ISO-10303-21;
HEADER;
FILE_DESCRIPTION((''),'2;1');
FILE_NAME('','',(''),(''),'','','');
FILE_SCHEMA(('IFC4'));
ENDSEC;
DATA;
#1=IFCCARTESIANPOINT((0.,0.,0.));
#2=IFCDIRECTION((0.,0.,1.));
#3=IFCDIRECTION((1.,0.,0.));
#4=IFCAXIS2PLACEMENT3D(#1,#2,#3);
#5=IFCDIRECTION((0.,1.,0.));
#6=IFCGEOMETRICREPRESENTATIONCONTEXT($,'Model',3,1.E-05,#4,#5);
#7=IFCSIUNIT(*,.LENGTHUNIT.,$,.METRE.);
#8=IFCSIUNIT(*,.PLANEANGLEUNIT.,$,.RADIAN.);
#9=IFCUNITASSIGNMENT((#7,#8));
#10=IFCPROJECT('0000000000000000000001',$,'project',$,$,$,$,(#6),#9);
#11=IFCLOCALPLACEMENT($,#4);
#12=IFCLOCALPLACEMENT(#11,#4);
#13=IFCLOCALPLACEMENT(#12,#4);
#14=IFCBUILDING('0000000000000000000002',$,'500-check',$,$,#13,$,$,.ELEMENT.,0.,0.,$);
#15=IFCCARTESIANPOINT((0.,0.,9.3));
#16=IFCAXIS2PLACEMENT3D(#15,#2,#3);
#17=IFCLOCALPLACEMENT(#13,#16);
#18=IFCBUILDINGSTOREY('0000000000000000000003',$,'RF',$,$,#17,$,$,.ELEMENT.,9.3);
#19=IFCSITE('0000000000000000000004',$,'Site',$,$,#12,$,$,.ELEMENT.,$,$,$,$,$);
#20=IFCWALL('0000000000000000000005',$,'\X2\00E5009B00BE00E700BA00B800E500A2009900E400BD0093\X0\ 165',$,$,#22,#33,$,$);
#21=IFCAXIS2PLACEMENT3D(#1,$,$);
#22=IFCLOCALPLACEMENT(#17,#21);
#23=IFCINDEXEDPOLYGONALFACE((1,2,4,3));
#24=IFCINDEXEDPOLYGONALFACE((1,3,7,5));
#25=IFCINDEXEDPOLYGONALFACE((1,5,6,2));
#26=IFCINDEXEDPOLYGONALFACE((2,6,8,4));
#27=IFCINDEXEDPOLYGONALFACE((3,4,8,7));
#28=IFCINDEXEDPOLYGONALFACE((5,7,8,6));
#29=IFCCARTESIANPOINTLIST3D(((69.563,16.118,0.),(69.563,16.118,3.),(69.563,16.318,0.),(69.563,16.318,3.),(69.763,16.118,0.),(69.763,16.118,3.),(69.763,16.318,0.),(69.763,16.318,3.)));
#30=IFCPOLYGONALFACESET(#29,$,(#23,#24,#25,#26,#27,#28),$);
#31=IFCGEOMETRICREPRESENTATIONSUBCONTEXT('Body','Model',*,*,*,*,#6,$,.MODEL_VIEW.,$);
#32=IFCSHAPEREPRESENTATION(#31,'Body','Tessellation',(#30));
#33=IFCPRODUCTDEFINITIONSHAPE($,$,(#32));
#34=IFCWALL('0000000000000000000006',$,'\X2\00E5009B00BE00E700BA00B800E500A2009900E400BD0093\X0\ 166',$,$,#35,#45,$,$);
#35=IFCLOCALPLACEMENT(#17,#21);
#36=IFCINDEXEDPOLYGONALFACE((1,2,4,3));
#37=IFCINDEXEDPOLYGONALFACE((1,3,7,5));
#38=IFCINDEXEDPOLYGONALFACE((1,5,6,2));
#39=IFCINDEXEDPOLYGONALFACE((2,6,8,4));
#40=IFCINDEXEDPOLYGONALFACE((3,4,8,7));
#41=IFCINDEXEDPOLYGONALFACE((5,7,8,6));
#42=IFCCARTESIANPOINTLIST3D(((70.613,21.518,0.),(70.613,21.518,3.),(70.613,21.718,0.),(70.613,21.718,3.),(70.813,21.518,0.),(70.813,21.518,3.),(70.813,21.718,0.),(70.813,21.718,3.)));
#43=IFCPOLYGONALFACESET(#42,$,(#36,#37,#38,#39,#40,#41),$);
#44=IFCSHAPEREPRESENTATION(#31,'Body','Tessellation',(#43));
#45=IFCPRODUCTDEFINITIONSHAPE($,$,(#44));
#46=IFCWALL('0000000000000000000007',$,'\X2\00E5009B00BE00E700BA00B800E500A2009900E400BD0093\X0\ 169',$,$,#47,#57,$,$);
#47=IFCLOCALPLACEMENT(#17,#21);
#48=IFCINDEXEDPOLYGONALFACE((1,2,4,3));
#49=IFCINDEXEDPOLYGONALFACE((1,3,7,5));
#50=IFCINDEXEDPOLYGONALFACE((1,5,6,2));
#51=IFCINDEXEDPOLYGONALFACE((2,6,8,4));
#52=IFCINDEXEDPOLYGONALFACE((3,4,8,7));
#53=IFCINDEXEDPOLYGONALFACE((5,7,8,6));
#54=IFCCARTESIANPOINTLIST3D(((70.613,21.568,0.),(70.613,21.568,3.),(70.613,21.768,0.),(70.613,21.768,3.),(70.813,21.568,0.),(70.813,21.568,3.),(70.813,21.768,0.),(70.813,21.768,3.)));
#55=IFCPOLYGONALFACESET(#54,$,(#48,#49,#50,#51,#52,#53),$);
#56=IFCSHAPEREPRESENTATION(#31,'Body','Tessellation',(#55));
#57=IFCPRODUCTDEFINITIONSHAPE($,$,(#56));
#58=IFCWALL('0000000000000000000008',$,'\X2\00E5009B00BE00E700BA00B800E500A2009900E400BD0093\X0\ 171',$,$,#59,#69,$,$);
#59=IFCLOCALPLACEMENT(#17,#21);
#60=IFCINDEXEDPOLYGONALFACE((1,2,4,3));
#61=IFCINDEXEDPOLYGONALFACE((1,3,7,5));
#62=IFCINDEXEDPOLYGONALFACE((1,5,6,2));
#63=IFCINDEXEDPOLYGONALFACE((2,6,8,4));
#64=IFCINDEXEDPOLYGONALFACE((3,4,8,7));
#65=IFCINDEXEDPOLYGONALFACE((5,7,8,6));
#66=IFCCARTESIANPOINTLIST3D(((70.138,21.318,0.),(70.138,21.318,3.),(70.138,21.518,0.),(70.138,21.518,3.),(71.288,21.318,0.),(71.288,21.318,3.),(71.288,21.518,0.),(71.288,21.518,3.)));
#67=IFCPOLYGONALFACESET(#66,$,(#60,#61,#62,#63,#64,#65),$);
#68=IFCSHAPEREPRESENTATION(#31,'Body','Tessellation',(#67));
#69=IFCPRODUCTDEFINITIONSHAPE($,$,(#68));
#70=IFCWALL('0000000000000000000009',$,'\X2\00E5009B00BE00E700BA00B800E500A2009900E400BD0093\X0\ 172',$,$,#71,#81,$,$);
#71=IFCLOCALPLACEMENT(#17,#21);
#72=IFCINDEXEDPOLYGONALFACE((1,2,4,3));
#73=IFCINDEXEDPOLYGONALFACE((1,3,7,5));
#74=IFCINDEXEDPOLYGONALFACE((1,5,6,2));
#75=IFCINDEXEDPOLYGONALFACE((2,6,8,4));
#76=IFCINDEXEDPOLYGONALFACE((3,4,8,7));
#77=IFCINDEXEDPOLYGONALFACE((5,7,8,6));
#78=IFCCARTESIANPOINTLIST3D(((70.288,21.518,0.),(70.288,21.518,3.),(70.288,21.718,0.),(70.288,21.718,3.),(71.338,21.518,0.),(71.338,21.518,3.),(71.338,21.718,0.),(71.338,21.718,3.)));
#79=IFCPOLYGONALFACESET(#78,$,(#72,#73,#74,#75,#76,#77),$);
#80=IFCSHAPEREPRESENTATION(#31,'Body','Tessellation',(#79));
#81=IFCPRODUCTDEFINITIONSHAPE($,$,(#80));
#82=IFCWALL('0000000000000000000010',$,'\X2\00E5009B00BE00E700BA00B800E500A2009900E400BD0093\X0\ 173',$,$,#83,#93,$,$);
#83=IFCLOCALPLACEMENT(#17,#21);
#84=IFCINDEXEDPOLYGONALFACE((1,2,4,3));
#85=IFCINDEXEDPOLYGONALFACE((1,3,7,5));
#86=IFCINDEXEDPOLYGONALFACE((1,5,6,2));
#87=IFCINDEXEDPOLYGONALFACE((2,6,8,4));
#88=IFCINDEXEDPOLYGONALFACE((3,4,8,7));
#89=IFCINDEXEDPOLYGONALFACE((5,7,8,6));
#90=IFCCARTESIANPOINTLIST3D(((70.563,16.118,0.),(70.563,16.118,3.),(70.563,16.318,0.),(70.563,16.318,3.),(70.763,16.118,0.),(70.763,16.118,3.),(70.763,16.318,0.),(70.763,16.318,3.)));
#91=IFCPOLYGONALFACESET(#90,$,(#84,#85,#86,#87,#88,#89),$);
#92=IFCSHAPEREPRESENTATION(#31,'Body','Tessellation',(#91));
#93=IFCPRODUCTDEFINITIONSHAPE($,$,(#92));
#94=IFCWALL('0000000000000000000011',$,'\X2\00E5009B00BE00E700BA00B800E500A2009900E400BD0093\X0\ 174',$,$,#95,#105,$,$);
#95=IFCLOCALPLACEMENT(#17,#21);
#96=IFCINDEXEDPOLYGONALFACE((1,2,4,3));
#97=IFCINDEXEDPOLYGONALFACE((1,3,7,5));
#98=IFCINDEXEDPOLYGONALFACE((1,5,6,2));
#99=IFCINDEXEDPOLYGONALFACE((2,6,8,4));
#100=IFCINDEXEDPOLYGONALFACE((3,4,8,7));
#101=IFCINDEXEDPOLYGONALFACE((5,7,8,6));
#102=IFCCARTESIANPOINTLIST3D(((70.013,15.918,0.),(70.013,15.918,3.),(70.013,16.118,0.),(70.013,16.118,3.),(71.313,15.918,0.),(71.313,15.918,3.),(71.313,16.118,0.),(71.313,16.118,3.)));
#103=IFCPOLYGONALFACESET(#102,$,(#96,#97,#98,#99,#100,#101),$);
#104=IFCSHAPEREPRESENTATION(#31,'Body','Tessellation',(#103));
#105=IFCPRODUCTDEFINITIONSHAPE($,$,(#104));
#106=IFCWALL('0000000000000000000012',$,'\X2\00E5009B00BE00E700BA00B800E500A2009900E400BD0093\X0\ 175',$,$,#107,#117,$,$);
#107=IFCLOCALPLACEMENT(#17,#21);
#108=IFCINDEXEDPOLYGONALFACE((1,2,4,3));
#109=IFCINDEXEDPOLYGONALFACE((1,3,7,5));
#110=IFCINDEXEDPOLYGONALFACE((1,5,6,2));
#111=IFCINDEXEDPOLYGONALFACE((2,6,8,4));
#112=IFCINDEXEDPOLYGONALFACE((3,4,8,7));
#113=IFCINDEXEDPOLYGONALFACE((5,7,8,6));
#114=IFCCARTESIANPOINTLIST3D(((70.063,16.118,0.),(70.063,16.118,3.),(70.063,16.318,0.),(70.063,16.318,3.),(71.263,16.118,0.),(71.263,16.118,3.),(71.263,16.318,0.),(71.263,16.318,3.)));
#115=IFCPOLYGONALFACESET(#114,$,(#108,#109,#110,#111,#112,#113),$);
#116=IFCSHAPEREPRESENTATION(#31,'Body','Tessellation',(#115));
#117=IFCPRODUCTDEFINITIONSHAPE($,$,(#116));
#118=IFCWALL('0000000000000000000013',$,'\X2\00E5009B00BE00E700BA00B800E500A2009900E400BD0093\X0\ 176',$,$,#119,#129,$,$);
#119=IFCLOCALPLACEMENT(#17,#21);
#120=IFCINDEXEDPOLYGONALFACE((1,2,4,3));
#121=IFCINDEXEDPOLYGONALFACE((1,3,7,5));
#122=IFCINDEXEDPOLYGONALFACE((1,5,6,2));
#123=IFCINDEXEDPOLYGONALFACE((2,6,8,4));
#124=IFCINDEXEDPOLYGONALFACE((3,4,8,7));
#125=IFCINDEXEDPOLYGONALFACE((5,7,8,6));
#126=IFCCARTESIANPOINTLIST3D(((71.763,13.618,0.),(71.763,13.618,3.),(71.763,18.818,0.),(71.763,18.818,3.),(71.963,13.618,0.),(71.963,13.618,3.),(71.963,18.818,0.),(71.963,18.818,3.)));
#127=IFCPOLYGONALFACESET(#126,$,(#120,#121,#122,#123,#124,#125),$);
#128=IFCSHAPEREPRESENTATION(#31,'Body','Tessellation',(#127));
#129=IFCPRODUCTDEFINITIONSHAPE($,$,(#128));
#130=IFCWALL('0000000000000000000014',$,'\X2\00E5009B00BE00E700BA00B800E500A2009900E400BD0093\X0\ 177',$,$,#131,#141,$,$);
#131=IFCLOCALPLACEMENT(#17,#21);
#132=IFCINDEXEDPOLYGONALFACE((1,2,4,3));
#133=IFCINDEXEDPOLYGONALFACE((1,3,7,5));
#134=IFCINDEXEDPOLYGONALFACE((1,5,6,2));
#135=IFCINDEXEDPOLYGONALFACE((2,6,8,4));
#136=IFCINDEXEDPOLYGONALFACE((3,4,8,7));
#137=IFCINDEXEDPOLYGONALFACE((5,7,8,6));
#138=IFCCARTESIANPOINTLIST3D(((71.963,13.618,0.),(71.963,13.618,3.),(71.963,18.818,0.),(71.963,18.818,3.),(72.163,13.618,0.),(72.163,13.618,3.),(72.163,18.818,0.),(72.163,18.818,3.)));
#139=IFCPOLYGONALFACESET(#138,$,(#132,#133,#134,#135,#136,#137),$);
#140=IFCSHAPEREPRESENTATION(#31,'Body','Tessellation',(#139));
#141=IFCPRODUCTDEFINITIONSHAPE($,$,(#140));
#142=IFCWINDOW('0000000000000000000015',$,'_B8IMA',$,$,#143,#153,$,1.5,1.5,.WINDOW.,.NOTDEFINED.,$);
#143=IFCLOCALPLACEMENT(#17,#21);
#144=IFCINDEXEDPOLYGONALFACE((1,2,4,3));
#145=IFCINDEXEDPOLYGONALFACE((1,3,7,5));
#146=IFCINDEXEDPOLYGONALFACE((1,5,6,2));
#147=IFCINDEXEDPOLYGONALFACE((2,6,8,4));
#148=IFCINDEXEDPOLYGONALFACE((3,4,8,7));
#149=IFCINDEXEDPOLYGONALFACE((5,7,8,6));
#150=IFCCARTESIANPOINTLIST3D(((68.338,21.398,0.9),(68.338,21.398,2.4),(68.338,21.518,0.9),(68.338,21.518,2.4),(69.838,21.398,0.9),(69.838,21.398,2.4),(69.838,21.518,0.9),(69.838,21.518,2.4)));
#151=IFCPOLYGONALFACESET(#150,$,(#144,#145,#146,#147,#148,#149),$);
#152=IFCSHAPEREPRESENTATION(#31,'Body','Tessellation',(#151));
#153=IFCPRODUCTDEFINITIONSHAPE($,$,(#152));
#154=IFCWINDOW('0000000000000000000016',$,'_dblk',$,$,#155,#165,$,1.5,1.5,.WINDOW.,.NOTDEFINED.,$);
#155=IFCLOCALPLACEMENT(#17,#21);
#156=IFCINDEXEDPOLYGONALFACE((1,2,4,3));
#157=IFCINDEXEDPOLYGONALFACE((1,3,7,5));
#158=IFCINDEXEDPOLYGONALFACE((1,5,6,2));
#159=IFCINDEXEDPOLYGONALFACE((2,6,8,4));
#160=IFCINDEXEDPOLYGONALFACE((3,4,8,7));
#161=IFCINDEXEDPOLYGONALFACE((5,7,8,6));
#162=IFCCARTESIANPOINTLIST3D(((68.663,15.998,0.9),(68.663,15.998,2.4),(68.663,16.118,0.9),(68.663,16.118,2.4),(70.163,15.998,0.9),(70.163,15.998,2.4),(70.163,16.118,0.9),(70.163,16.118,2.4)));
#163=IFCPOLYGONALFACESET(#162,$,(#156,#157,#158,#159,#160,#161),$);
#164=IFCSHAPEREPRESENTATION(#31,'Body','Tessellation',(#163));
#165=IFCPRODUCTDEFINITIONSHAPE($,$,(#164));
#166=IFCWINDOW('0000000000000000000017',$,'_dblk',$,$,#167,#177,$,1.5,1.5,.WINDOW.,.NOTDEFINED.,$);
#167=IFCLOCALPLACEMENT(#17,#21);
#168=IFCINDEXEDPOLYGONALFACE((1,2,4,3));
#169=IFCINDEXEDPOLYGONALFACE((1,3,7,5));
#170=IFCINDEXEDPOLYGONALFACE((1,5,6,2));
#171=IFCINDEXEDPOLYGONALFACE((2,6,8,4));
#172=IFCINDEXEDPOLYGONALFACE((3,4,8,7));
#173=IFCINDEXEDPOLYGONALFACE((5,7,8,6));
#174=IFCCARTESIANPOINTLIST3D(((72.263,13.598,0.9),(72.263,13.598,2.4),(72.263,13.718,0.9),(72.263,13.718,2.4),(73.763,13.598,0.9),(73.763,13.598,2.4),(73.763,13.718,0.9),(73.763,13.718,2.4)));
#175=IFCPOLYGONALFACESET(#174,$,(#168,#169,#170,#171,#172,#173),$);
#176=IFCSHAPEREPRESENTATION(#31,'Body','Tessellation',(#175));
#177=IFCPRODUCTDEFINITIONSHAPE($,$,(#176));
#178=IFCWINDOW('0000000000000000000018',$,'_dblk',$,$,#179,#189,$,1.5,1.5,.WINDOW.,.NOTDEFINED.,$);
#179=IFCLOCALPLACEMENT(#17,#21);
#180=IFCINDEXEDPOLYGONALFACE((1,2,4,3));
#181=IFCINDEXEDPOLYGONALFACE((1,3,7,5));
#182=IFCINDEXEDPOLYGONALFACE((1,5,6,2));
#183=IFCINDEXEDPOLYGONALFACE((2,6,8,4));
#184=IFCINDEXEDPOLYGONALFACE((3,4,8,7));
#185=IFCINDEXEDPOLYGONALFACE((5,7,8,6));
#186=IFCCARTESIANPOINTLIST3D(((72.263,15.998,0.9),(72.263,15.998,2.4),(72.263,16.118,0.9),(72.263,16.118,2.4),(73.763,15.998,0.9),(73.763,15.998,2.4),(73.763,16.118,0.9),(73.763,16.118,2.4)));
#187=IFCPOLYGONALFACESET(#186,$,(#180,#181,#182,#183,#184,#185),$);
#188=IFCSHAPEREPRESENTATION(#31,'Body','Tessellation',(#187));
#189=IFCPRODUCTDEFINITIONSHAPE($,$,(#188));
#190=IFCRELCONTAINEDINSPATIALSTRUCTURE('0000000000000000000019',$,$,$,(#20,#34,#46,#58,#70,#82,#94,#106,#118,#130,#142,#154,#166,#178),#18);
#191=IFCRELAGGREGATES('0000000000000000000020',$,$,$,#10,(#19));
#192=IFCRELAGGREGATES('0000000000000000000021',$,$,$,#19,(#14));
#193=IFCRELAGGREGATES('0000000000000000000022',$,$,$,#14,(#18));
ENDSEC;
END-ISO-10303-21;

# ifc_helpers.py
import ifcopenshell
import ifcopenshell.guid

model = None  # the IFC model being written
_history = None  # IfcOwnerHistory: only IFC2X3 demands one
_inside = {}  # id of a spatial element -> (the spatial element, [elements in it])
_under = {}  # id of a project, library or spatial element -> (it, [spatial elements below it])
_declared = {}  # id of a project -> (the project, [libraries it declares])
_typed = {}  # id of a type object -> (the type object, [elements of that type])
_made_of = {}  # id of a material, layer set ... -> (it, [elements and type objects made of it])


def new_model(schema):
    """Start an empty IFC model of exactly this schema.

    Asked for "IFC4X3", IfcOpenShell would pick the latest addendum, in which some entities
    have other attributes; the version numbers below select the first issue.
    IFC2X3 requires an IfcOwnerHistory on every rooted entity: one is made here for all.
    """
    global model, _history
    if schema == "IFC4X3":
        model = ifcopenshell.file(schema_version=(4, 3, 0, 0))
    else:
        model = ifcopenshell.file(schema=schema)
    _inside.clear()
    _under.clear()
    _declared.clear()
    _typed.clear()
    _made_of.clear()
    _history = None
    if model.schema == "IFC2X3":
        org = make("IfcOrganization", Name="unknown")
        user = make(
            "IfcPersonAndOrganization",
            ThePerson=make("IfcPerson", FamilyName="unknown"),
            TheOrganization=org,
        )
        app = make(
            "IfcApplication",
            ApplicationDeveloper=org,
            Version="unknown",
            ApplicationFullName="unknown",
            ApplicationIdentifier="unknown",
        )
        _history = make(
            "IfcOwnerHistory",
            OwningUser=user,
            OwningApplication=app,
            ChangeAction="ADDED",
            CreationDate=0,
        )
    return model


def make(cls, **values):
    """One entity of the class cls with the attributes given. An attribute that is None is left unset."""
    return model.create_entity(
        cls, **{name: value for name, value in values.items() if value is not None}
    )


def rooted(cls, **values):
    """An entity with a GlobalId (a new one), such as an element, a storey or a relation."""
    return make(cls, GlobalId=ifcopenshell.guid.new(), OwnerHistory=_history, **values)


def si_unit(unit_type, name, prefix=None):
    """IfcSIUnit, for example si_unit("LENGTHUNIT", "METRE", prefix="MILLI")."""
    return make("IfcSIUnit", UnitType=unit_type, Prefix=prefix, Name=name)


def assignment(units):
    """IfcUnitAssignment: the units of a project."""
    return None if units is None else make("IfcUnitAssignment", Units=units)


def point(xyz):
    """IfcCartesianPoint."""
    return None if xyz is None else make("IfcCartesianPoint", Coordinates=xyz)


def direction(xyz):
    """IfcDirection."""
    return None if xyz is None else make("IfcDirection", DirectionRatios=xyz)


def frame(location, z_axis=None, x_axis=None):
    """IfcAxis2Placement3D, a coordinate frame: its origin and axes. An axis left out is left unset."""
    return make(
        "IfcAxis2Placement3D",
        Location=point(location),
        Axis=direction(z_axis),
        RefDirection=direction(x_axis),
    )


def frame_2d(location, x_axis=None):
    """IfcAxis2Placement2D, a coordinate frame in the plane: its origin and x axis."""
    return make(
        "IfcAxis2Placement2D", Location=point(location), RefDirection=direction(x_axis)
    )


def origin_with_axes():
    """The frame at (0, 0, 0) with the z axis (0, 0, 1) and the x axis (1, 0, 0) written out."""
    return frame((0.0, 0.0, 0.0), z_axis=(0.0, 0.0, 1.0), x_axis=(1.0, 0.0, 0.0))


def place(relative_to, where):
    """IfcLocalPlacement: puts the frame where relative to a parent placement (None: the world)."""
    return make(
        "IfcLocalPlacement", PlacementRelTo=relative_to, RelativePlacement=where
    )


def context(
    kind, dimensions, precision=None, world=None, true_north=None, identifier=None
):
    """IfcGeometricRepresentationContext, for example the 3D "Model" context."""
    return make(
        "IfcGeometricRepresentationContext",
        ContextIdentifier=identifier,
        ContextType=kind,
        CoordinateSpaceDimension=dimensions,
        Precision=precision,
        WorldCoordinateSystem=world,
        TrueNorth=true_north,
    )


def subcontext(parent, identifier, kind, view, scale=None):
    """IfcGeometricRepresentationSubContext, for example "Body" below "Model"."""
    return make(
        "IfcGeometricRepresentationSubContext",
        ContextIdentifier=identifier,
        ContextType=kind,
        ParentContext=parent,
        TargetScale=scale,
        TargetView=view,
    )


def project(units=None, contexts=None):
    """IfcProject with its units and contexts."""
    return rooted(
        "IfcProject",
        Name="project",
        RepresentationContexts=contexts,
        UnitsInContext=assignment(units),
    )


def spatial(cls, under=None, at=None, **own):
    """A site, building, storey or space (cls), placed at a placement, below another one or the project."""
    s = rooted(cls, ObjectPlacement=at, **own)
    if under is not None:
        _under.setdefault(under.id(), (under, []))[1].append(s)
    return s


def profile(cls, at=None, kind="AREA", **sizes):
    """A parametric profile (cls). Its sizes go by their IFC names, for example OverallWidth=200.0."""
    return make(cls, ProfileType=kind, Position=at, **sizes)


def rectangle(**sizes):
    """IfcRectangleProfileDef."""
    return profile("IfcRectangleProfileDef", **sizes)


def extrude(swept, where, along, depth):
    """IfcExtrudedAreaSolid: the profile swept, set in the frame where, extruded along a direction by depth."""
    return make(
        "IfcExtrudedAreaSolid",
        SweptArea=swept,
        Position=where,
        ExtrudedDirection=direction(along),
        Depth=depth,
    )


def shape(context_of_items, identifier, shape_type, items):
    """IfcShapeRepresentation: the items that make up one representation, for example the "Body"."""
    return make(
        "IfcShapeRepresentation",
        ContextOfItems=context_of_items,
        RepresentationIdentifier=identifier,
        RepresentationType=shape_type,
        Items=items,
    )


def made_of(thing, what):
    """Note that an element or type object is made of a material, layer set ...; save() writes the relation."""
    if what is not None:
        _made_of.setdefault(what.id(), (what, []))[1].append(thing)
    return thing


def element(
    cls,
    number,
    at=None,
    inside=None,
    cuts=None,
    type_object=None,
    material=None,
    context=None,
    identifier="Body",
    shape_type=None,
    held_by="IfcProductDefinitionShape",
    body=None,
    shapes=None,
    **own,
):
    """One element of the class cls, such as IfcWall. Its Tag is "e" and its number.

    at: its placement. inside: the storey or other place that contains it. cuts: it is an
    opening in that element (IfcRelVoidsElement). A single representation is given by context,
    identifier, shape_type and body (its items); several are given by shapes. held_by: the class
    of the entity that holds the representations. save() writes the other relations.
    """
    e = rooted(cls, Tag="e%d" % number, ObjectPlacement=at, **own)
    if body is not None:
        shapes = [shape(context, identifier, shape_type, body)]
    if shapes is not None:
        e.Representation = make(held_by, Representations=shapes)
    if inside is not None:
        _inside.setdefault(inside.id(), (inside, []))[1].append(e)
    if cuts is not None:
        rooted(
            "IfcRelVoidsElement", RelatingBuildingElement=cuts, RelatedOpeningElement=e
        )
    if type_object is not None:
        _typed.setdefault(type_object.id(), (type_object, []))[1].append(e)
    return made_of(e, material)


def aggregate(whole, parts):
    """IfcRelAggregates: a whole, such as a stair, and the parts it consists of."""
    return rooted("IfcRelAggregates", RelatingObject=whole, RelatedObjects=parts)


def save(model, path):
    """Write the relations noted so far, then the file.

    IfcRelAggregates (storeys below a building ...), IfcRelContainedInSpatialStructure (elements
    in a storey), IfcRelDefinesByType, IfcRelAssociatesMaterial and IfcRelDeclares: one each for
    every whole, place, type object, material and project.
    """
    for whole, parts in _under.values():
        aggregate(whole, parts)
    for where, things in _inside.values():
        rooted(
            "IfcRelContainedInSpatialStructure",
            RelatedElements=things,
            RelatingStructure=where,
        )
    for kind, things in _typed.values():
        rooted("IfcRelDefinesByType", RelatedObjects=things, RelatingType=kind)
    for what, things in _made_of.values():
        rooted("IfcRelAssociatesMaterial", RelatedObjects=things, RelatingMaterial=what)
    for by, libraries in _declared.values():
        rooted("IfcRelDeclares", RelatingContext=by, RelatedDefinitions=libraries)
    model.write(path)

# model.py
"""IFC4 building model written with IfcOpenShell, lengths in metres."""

from ifc_helpers import new_model, si_unit, direction, frame, frame_2d, origin_with_axes, place, context, subcontext, project, spatial, rectangle, extrude, element, save


model = new_model("IFC4")

# Units and contexts
model_context = context("Model", 3, precision=1e-05, world=origin_with_axes(), true_north=direction((0.0, 1.0, 0.0)))
body_context = subcontext(model_context, "Body", "Model", "MODEL_VIEW")
ifc_project = project(units=[si_unit("LENGTHUNIT", "METRE"), si_unit("PLANEANGLEUNIT", "RADIAN")], contexts=[model_context])

# Site, building, storey
placement = place(None, origin_with_axes())
site_placement = place(placement, origin_with_axes())
site = spatial("IfcSite", under=ifc_project, at=site_placement, Name="Site", CompositionType="ELEMENT")
building_placement = place(site_placement, origin_with_axes())
building = spatial("IfcBuilding", under=site, at=building_placement, Name="500-check", CompositionType="ELEMENT", ElevationOfRefHeight=0.0, ElevationOfTerrain=0.0)
storey_placement = place(building_placement, frame((0.0, 0.0, 9.3), z_axis=(0.0, 0.0, 1.0), x_axis=(1.0, 0.0, 0.0)))
storey = spatial("IfcBuildingStorey", under=building, at=storey_placement, Name="RF", CompositionType="ELEMENT", Elevation=9.3)

# Walls
for number, where, z_axis, x_axis, name in (
    (1, (69.663, 16.218, 0.0), (0.0, 0.0, 1.0), (0.0, -1.0, 0.0), "å\u009b¾çº¸å¢\u0099ä½\u0093 165"),
    (2, (70.713, 21.618, 0.0), (0.0, 0.0, 1.0), (0.0, -1.0, 0.0), "å\u009b¾çº¸å¢\u0099ä½\u0093 166"),
    (3, (70.713, 21.668, 0.0), (0.0, 0.0, 1.0), (0.0, -1.0, 0.0), "å\u009b¾çº¸å¢\u0099ä½\u0093 169"),
):
    element("IfcWall", number, at=place(storey_placement, frame(where, z_axis=z_axis, x_axis=x_axis)), inside=storey, Name=name, context=body_context, shape_type="SweptSolid", body=[
        extrude(rectangle(XDim=0.2, YDim=0.2, at=frame_2d((0.0, 0.0), x_axis=(1.0, 0.0, 0.0))), frame((0.0, 0.0, 0.0), z_axis=(0.0, 0.0, 1.0)), (0.0, 0.0, 1.0), 3.0),
    ])
wall_1_placement = place(storey_placement, frame((70.713, 21.418, 0.0), z_axis=(0.0, 0.0, 1.0), x_axis=(1.0, 0.0, 0.0)))
element("IfcWall", 4, at=wall_1_placement, inside=storey, Name="å\u009b¾çº¸å¢\u0099ä½\u0093 171", context=body_context, shape_type="SweptSolid", body=[
    extrude(rectangle(XDim=1.15, YDim=0.2, at=frame_2d((0.0, 0.0), x_axis=(1.0, 0.0, 0.0))), frame((0.0, 0.0, 0.0), z_axis=(0.0, 0.0, 1.0)), (0.0, 0.0, 1.0), 3.0),
])
wall_2_placement = place(storey_placement, frame((70.813, 21.618, 0.0), z_axis=(0.0, 0.0, 1.0), x_axis=(1.0, 0.0, 0.0)))
element("IfcWall", 5, at=wall_2_placement, inside=storey, Name="å\u009b¾çº¸å¢\u0099ä½\u0093 172", context=body_context, shape_type="SweptSolid", body=[
    extrude(rectangle(XDim=1.05, YDim=0.2, at=frame_2d((0.0, 0.0), x_axis=(1.0, 0.0, 0.0))), frame((0.0, 0.0, 0.0), z_axis=(0.0, 0.0, 1.0)), (0.0, 0.0, 1.0), 3.0),
])
wall_3_placement = place(storey_placement, frame((70.663, 16.218, 0.0), z_axis=(0.0, 0.0, 1.0), x_axis=(0.0, -1.0, 0.0)))
element("IfcWall", 6, at=wall_3_placement, inside=storey, Name="å\u009b¾çº¸å¢\u0099ä½\u0093 173", context=body_context, shape_type="SweptSolid", body=[
    extrude(rectangle(XDim=0.2, YDim=0.2, at=frame_2d((0.0, 0.0), x_axis=(1.0, 0.0, 0.0))), frame((0.0, 0.0, 0.0), z_axis=(0.0, 0.0, 1.0)), (0.0, 0.0, 1.0), 3.0),
])
wall_4_placement = place(storey_placement, frame((70.663, 16.018, 0.0), z_axis=(0.0, 0.0, 1.0), x_axis=(1.0, 0.0, 0.0)))
element("IfcWall", 7, at=wall_4_placement, inside=storey, Name="å\u009b¾çº¸å¢\u0099ä½\u0093 174", context=body_context, shape_type="SweptSolid", body=[
    extrude(rectangle(XDim=1.3, YDim=0.2, at=frame_2d((0.0, 0.0), x_axis=(1.0, 0.0, 0.0))), frame((0.0, 0.0, 0.0), z_axis=(0.0, 0.0, 1.0)), (0.0, 0.0, 1.0), 3.0),
])
wall_5_placement = place(storey_placement, frame((70.663, 16.218, 0.0), z_axis=(0.0, 0.0, 1.0), x_axis=(1.0, 0.0, 0.0)))
element("IfcWall", 8, at=wall_5_placement, inside=storey, Name="å\u009b¾çº¸å¢\u0099ä½\u0093 175", context=body_context, shape_type="SweptSolid", body=[
    extrude(rectangle(XDim=1.2, YDim=0.2, at=frame_2d((0.0, 0.0), x_axis=(1.0, 0.0, 0.0))), frame((0.0, 0.0, 0.0), z_axis=(0.0, 0.0, 1.0)), (0.0, 0.0, 1.0), 3.0),
])
for number, where, z_axis, x_axis, name in (
    (9, (71.863, 16.218, 0.0), (0.0, 0.0, 1.0), (0.0, 1.0, 0.0), "å\u009b¾çº¸å¢\u0099ä½\u0093 176"),
    (10, (72.063, 16.218, 0.0), (0.0, 0.0, 1.0), (0.0, 1.0, 0.0), "å\u009b¾çº¸å¢\u0099ä½\u0093 177"),
):
    element("IfcWall", number, at=place(storey_placement, frame(where, z_axis=z_axis, x_axis=x_axis)), inside=storey, Name=name, context=body_context, shape_type="SweptSolid", body=[
        extrude(rectangle(XDim=5.2, YDim=0.2, at=frame_2d((0.0, 0.0), x_axis=(1.0, 0.0, 0.0))), frame((0.0, 0.0, 0.0), z_axis=(0.0, 0.0, 1.0)), (0.0, 0.0, 1.0), 3.0),
    ])

# Windows
for number, where, z_axis, x_axis, name in (
    (11, (69.088, 21.458, 0.9), (0.0, 0.0, 1.0), (1.0, 0.0, 0.0), "_B8IMA"),
    (12, (69.413, 16.058, 0.9), (0.0, 0.0, 1.0), (1.0, 0.0, 0.0), "_dblk"),
    (13, (73.013, 13.658, 0.9), (0.0, 0.0, 1.0), (1.0, 0.0, 0.0), "_dblk"),
    (14, (73.013, 16.058, 0.9), (0.0, 0.0, 1.0), (1.0, 0.0, 0.0), "_dblk"),
):
    element("IfcWindow", number, at=place(storey_placement, frame(where, z_axis=z_axis, x_axis=x_axis)), inside=storey, Name=name, OverallHeight=1.5, OverallWidth=1.5, PartitioningType="NOTDEFINED", PredefinedType="WINDOW", context=body_context, shape_type="SweptSolid", body=[
        extrude(rectangle(XDim=1.5, YDim=0.12, at=frame_2d((0.0, 0.0), x_axis=(1.0, 0.0, 0.0))), frame((0.0, 0.0, 0.0), z_axis=(0.0, 0.0, 1.0)), (0.0, 0.0, 1.0), 1.5),
    ])

save(model, "model.ifc")
